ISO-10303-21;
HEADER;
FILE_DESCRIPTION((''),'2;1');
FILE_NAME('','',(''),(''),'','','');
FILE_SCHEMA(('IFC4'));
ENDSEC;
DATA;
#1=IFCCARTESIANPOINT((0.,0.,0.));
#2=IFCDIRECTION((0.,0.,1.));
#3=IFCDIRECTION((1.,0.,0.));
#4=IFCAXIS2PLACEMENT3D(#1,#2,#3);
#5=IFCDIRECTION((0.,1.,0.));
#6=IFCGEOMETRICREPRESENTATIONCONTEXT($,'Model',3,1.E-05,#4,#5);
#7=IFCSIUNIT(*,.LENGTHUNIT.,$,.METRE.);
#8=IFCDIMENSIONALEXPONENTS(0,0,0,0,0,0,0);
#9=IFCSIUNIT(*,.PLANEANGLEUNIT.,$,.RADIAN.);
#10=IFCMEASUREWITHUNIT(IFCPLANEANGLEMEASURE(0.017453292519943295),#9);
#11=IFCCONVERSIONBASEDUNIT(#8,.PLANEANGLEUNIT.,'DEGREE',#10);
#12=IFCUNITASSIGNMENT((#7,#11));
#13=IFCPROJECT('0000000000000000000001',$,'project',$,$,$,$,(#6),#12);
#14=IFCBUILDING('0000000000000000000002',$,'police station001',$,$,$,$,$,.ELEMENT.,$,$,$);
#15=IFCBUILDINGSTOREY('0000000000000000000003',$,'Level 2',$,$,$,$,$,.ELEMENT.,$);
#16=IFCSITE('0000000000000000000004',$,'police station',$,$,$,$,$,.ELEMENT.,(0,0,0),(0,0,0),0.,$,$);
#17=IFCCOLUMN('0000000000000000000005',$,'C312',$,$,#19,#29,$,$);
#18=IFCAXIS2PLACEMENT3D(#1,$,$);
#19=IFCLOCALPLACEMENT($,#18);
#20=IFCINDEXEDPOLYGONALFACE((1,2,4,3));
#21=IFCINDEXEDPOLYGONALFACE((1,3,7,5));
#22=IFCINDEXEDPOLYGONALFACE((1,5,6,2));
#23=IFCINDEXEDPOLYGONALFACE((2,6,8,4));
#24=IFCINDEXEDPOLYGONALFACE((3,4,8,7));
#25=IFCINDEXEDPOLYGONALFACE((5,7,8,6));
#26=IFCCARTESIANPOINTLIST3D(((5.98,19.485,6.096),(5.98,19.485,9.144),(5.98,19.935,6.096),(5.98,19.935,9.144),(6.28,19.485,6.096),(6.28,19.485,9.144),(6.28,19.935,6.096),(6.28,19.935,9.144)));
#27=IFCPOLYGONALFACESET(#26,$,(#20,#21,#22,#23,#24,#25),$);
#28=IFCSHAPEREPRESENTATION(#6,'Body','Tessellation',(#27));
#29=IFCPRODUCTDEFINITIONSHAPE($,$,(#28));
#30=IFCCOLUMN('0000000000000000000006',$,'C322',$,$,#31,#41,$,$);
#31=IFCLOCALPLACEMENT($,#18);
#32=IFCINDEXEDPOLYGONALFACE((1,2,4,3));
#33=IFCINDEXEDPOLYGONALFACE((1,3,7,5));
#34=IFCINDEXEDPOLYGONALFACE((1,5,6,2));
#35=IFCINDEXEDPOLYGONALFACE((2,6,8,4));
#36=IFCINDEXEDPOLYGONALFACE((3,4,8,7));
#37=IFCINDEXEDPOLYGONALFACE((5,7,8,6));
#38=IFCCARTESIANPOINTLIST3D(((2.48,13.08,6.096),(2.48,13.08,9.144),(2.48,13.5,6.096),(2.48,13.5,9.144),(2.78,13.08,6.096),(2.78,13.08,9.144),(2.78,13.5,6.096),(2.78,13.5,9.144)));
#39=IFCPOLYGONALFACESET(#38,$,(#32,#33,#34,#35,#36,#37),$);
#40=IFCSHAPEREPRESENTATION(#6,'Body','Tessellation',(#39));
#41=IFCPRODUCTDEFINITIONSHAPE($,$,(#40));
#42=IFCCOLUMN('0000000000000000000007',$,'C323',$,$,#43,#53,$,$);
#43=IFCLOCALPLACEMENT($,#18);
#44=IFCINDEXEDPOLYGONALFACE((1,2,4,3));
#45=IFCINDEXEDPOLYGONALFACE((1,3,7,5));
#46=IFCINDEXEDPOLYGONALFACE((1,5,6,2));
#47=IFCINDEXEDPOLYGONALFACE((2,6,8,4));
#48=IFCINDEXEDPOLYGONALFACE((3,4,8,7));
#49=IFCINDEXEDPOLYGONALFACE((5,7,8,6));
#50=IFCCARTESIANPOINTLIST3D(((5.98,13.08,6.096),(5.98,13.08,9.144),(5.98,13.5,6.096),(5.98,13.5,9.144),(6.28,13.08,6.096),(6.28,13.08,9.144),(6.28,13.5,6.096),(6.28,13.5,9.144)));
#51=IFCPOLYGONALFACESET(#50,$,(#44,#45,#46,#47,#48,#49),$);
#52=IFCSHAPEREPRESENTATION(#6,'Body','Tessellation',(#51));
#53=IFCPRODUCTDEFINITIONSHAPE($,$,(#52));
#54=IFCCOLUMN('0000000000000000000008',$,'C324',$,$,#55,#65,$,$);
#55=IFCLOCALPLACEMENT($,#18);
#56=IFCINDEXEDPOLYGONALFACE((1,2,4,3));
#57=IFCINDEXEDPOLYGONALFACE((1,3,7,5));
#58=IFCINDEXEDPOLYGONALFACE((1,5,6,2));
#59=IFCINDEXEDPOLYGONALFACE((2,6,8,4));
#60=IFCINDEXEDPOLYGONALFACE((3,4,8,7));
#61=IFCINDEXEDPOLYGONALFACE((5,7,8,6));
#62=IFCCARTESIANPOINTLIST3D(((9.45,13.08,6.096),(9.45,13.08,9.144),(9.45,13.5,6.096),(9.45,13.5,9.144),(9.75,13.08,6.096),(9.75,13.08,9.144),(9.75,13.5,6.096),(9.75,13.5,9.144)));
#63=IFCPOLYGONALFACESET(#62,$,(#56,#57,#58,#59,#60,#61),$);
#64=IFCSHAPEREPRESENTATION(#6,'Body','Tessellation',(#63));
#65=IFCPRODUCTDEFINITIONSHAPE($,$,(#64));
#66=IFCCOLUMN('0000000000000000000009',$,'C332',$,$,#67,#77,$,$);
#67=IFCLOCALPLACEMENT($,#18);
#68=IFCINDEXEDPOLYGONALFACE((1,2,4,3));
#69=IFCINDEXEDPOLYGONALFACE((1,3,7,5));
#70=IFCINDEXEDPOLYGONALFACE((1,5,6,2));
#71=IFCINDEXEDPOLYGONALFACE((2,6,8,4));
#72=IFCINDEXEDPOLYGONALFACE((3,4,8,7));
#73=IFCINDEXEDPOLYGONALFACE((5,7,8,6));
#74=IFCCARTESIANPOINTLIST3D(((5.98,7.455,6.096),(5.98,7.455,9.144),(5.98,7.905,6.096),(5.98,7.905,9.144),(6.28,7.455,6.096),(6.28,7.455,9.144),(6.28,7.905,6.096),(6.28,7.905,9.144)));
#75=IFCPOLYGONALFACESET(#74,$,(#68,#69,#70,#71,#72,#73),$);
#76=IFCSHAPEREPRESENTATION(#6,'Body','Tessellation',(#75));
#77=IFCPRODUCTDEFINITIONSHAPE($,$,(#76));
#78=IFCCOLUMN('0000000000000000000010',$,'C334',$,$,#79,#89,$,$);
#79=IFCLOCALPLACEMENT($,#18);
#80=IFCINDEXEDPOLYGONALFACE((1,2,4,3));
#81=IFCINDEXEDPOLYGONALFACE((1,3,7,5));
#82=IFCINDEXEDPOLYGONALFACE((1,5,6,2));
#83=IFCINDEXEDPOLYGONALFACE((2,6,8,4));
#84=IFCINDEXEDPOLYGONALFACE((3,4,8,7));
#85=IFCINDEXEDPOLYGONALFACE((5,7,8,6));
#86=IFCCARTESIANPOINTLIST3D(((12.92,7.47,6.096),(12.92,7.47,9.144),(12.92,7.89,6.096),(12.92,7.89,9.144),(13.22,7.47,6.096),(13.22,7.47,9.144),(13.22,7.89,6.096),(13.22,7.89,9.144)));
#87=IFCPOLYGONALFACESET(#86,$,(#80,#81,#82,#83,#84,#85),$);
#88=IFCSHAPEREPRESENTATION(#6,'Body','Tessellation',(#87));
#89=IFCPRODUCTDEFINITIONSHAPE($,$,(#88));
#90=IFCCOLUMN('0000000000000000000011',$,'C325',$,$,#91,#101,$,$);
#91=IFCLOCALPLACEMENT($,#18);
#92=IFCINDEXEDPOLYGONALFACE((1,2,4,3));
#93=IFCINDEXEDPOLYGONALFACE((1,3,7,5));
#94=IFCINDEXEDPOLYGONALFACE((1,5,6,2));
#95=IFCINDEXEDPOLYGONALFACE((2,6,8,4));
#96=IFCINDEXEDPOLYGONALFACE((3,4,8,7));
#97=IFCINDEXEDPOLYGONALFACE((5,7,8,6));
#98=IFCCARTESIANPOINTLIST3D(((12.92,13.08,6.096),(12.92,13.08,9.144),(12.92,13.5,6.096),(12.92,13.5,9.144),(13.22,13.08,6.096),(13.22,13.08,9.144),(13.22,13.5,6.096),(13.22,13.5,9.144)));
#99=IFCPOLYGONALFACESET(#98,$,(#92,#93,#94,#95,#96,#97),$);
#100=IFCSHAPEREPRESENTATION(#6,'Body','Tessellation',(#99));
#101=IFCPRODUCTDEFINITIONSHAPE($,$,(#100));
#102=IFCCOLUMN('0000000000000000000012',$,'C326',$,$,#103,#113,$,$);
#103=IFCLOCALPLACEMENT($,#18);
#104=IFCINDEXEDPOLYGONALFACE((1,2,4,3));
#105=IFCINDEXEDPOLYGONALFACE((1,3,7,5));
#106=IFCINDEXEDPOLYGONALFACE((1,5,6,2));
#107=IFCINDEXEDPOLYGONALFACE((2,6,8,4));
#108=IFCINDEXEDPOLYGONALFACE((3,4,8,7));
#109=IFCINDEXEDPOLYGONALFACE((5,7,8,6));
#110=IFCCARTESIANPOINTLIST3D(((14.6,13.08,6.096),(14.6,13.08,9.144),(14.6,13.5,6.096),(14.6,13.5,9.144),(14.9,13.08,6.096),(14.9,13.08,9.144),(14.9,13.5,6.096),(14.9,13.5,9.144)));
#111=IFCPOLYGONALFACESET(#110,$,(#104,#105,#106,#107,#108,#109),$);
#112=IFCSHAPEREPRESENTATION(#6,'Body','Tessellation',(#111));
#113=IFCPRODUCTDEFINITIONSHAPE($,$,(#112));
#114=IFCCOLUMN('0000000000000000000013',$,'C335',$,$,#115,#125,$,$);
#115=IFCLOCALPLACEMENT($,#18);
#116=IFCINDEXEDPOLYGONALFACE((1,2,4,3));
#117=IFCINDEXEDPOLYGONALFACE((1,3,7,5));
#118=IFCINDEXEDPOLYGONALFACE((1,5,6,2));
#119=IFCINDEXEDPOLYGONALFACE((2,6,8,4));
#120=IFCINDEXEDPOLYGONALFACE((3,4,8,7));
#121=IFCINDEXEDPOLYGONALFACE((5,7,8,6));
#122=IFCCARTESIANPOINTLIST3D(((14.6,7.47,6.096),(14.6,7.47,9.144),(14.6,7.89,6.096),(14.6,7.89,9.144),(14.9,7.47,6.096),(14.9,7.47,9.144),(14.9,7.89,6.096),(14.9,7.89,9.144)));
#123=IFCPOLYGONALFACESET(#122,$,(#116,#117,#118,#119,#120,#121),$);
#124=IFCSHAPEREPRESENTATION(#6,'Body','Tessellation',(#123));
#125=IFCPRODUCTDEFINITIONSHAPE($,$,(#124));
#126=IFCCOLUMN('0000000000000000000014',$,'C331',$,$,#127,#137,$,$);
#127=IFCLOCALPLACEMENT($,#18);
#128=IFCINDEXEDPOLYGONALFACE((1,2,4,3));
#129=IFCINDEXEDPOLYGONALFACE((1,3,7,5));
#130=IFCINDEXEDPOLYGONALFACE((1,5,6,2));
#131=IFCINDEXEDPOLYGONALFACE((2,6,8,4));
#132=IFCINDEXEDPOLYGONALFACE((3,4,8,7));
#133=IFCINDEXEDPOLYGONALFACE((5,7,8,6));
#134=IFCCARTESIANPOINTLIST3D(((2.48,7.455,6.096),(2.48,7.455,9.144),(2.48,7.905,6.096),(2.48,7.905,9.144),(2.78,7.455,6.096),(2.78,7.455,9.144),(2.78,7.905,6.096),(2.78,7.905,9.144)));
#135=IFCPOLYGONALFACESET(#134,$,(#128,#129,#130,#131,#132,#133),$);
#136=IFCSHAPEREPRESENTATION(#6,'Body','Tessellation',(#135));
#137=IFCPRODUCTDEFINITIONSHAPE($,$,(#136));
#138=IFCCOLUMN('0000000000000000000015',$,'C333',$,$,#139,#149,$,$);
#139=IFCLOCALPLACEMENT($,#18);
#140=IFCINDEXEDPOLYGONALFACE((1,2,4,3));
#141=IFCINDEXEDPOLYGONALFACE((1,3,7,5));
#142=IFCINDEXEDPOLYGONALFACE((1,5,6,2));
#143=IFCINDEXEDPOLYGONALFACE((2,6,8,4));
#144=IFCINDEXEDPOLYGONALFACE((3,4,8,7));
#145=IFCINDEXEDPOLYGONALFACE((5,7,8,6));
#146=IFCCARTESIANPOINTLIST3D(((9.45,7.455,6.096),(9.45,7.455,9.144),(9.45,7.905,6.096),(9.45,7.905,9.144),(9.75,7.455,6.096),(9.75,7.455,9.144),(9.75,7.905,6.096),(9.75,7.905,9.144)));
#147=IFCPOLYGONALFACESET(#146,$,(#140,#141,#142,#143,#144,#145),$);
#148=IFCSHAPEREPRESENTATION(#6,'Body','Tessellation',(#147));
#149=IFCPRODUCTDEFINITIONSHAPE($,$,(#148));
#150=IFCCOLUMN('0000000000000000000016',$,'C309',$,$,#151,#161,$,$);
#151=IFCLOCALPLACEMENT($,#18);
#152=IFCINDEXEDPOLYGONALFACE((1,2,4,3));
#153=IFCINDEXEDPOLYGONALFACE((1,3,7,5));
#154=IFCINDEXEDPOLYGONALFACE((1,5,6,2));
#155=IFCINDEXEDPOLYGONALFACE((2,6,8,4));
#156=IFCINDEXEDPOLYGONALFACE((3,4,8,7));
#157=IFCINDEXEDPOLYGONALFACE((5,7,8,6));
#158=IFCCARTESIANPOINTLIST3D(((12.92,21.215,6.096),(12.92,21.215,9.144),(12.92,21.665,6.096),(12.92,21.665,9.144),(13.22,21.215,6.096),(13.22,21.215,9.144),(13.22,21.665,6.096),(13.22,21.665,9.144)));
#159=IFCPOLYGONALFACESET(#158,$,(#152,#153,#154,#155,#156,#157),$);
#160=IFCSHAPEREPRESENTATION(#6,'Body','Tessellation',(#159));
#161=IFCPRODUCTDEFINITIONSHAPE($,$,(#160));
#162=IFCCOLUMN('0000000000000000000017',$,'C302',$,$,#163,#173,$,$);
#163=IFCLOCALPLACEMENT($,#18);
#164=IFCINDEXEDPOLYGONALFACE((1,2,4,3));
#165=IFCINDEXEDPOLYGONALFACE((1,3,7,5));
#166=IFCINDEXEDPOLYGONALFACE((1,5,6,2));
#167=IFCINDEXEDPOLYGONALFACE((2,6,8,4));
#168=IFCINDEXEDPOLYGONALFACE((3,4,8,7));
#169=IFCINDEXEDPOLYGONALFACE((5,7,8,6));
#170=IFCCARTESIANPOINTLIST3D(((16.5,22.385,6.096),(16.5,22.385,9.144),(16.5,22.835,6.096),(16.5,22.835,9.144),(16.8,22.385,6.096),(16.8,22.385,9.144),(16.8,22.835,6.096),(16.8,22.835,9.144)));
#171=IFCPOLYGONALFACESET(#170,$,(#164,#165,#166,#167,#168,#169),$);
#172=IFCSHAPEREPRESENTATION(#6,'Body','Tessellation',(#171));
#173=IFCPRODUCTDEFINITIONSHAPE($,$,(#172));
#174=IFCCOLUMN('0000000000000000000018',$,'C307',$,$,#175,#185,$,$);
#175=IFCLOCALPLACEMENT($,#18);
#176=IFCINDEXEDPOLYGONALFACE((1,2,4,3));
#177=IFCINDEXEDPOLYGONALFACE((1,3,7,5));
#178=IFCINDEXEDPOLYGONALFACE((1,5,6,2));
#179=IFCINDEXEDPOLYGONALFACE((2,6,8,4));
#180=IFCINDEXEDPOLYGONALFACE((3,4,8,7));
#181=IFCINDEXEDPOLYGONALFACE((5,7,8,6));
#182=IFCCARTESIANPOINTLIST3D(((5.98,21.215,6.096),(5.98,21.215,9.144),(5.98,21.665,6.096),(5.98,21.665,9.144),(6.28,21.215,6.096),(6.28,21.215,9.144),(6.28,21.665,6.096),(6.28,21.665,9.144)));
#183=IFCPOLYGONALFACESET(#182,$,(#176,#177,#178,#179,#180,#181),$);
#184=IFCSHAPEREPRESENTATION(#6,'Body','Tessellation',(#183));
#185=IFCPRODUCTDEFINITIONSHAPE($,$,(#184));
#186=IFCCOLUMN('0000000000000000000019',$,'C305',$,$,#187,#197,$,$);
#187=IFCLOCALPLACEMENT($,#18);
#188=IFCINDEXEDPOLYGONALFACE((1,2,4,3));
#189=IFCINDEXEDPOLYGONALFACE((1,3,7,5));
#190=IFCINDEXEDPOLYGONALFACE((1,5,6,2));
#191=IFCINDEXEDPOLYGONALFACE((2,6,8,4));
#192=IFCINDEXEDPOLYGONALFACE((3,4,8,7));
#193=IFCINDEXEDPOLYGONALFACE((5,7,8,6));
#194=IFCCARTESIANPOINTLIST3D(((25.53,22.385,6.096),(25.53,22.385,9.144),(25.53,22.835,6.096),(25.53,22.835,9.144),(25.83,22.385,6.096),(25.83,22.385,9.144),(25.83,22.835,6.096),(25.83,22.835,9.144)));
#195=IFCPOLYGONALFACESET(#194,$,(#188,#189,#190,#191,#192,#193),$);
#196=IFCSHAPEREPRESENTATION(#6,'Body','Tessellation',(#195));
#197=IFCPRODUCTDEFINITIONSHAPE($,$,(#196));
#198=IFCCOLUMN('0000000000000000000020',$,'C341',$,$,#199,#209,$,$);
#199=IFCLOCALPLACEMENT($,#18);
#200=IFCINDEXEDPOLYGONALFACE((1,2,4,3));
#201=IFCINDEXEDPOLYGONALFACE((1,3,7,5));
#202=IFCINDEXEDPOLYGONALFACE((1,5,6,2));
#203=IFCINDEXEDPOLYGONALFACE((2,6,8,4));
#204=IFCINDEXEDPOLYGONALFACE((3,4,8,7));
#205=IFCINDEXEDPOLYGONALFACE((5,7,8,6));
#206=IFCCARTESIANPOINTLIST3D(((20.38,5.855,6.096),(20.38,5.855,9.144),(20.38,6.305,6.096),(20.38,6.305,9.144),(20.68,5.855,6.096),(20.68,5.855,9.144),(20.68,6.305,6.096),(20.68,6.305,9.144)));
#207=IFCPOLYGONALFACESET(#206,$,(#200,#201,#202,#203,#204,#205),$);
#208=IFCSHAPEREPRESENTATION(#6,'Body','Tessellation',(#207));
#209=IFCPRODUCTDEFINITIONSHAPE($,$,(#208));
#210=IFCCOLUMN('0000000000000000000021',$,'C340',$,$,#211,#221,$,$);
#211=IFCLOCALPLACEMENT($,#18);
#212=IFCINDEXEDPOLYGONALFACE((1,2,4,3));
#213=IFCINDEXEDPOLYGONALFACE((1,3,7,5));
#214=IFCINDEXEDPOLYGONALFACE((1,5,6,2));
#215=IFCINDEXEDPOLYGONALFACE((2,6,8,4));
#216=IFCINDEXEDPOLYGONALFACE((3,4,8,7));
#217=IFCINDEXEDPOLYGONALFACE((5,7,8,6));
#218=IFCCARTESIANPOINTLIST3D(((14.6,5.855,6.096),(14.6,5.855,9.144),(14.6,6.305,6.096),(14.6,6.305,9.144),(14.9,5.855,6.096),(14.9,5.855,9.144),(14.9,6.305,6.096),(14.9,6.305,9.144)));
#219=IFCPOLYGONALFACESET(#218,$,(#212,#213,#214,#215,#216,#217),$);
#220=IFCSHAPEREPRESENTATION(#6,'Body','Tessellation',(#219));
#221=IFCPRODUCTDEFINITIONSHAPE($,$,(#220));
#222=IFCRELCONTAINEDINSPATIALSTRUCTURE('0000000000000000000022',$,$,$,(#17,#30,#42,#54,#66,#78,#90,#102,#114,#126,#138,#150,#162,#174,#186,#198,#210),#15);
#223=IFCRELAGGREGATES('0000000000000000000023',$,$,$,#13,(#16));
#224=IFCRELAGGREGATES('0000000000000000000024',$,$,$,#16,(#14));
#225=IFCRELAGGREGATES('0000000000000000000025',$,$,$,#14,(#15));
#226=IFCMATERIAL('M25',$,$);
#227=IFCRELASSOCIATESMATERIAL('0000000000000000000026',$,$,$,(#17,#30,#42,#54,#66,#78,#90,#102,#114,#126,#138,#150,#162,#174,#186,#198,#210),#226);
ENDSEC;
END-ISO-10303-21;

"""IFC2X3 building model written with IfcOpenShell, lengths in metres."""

from ifc_helpers import new_model, entity, si_unit, converted_unit, direction, frame, frame_2d, origin_with_axes, place, context, project, spatial, rectangle, extrude, material, element, save


model = new_model("IFC2X3")

# Units and contexts
model_context = context("Model", 3, precision=1e-05, world=origin_with_axes(), true_north=direction((0.0, 1.0, 0.0)))
ifc_project = project(units=[si_unit("LENGTHUNIT", "METRE"), converted_unit("PLANEANGLEUNIT", "DEGREE", entity("IfcPlaneAngleMeasure", 0.017453292519943295), si_unit("PLANEANGLEUNIT", "RADIAN"), dimensions=[0, 0, 0, 0, 0, 0, 0])], contexts=[model_context])

# Site, building, storey
site = spatial("IfcSite", under=ifc_project, Name="police station", CompositionType="ELEMENT", RefLatitude=(0, 0, 0), RefLongitude=(0, 0, 0), RefElevation=0.0)
building = spatial("IfcBuilding", under=site, Name="police station001", CompositionType="ELEMENT")
storey = spatial("IfcBuildingStorey", under=building, Name="Level 2", CompositionType="ELEMENT")

# Columns
ifc_material = material(Name="M25")
placement = place(None, origin_with_axes())
element("IfcColumn", 1, at=placement, inside=storey, material=ifc_material, Name="C312", context=model_context, shape_type="SweptSolid", body=[
    extrude(rectangle(XDim=0.3, YDim=0.45, at=frame_2d((0.0, 0.0), x_axis=(1.0, 0.0, 0.0))), frame((6.13, 19.71, 6.096), z_axis=(0.0, 0.0, 1.0), x_axis=(1.0, 0.0, 0.0)), (0.0, 0.0, 1.0), 3.048),
])
element("IfcColumn", 2, at=placement, inside=storey, material=ifc_material, Name="C322", context=model_context, shape_type="SweptSolid", body=[
    extrude(rectangle(XDim=0.3, YDim=0.42, at=frame_2d((0.0, 0.0), x_axis=(1.0, 0.0, 0.0))), frame((2.63, 13.29, 6.096), z_axis=(0.0, 0.0, 1.0), x_axis=(1.0, 0.0, 0.0)), (0.0, 0.0, 1.0), 3.048),
])
element("IfcColumn", 3, at=placement, inside=storey, material=ifc_material, Name="C323", context=model_context, shape_type="SweptSolid", body=[
    extrude(rectangle(XDim=0.3, YDim=0.42, at=frame_2d((0.0, 0.0), x_axis=(1.0, 0.0, 0.0))), frame((6.13, 13.29, 6.096), z_axis=(0.0, 0.0, 1.0), x_axis=(1.0, 0.0, 0.0)), (0.0, 0.0, 1.0), 3.048),
])
element("IfcColumn", 4, at=placement, inside=storey, material=ifc_material, Name="C324", context=model_context, shape_type="SweptSolid", body=[
    extrude(rectangle(XDim=0.3, YDim=0.42, at=frame_2d((0.0, 0.0), x_axis=(1.0, 0.0, 0.0))), frame((9.6, 13.29, 6.096), z_axis=(0.0, 0.0, 1.0), x_axis=(1.0, 0.0, 0.0)), (0.0, 0.0, 1.0), 3.048),
])
element("IfcColumn", 5, at=placement, inside=storey, material=ifc_material, Name="C332", context=model_context, shape_type="SweptSolid", body=[
    extrude(rectangle(XDim=0.3, YDim=0.45, at=frame_2d((0.0, 0.0), x_axis=(1.0, 0.0, 0.0))), frame((6.13, 7.68, 6.096), z_axis=(0.0, 0.0, 1.0), x_axis=(1.0, 0.0, 0.0)), (0.0, 0.0, 1.0), 3.048),
])
element("IfcColumn", 6, at=placement, inside=storey, material=ifc_material, Name="C334", context=model_context, shape_type="SweptSolid", body=[
    extrude(rectangle(XDim=0.3, YDim=0.42, at=frame_2d((0.0, 0.0), x_axis=(1.0, 0.0, 0.0))), frame((13.07, 7.68, 6.096), z_axis=(0.0, 0.0, 1.0), x_axis=(1.0, 0.0, 0.0)), (0.0, 0.0, 1.0), 3.048),
])
element("IfcColumn", 7, at=placement, inside=storey, material=ifc_material, Name="C325", context=model_context, shape_type="SweptSolid", body=[
    extrude(rectangle(XDim=0.3, YDim=0.42, at=frame_2d((0.0, 0.0), x_axis=(1.0, 0.0, 0.0))), frame((13.07, 13.29, 6.096), z_axis=(0.0, 0.0, 1.0), x_axis=(1.0, 0.0, 0.0)), (0.0, 0.0, 1.0), 3.048),
])
element("IfcColumn", 8, at=placement, inside=storey, material=ifc_material, Name="C326", context=model_context, shape_type="SweptSolid", body=[
    extrude(rectangle(XDim=0.3, YDim=0.42, at=frame_2d((0.0, 0.0), x_axis=(1.0, 0.0, 0.0))), frame((14.75, 13.29, 6.096), z_axis=(0.0, 0.0, 1.0), x_axis=(1.0, 0.0, 0.0)), (0.0, 0.0, 1.0), 3.048),
])
element("IfcColumn", 9, at=placement, inside=storey, material=ifc_material, Name="C335", context=model_context, shape_type="SweptSolid", body=[
    extrude(rectangle(XDim=0.3, YDim=0.42, at=frame_2d((0.0, 0.0), x_axis=(1.0, 0.0, 0.0))), frame((14.75, 7.68, 6.096), z_axis=(0.0, 0.0, 1.0), x_axis=(1.0, 0.0, 0.0)), (0.0, 0.0, 1.0), 3.048),
])
element("IfcColumn", 10, at=placement, inside=storey, material=ifc_material, Name="C331", context=model_context, shape_type="SweptSolid", body=[
    extrude(rectangle(XDim=0.3, YDim=0.45, at=frame_2d((0.0, 0.0), x_axis=(1.0, 0.0, 0.0))), frame((2.63, 7.68, 6.096), z_axis=(0.0, 0.0, 1.0), x_axis=(1.0, 0.0, 0.0)), (0.0, 0.0, 1.0), 3.048),
])
element("IfcColumn", 11, at=placement, inside=storey, material=ifc_material, Name="C333", context=model_context, shape_type="SweptSolid", body=[
    extrude(rectangle(XDim=0.3, YDim=0.45, at=frame_2d((0.0, 0.0), x_axis=(1.0, 0.0, 0.0))), frame((9.6, 7.68, 6.096), z_axis=(0.0, 0.0, 1.0), x_axis=(1.0, 0.0, 0.0)), (0.0, 0.0, 1.0), 3.048),
])
element("IfcColumn", 12, at=placement, inside=storey, material=ifc_material, Name="C309", context=model_context, shape_type="SweptSolid", body=[
    extrude(rectangle(XDim=0.3, YDim=0.45, at=frame_2d((0.0, 0.0), x_axis=(1.0, 0.0, 0.0))), frame((13.07, 21.44, 6.096), z_axis=(0.0, 0.0, 1.0), x_axis=(1.0, 0.0, 0.0)), (0.0, 0.0, 1.0), 3.048),
])
element("IfcColumn", 13, at=placement, inside=storey, material=ifc_material, Name="C302", context=model_context, shape_type="SweptSolid", body=[
    extrude(rectangle(XDim=0.3, YDim=0.45, at=frame_2d((0.0, 0.0), x_axis=(1.0, 0.0, 0.0))), frame((16.65, 22.61, 6.096), z_axis=(0.0, 0.0, 1.0), x_axis=(1.0, 0.0, 0.0)), (0.0, 0.0, 1.0), 3.048),
])
element("IfcColumn", 14, at=placement, inside=storey, material=ifc_material, Name="C307", context=model_context, shape_type="SweptSolid", body=[
    extrude(rectangle(XDim=0.3, YDim=0.45, at=frame_2d((0.0, 0.0), x_axis=(1.0, 0.0, 0.0))), frame((6.13, 21.44, 6.096), z_axis=(0.0, 0.0, 1.0), x_axis=(1.0, 0.0, 0.0)), (0.0, 0.0, 1.0), 3.048),
])
element("IfcColumn", 15, at=placement, inside=storey, material=ifc_material, Name="C305", context=model_context, shape_type="SweptSolid", body=[
    extrude(rectangle(XDim=0.3, YDim=0.45, at=frame_2d((0.0, 0.0), x_axis=(1.0, 0.0, 0.0))), frame((25.68, 22.61, 6.096), z_axis=(0.0, 0.0, 1.0), x_axis=(1.0, 0.0, 0.0)), (0.0, 0.0, 1.0), 3.048),
])
element("IfcColumn", 16, at=placement, inside=storey, material=ifc_material, Name="C341", context=model_context, shape_type="SweptSolid", body=[
    extrude(rectangle(XDim=0.3, YDim=0.45, at=frame_2d((0.0, 0.0), x_axis=(1.0, 0.0, 0.0))), frame((20.53, 6.08, 6.096), z_axis=(0.0, 0.0, 1.0), x_axis=(1.0, 0.0, 0.0)), (0.0, 0.0, 1.0), 3.048),
])
element("IfcColumn", 17, at=placement, inside=storey, material=ifc_material, Name="C340", context=model_context, shape_type="SweptSolid", body=[
    extrude(rectangle(XDim=0.3, YDim=0.45, at=frame_2d((0.0, 0.0), x_axis=(1.0, 0.0, 0.0))), frame((14.75, 6.08, 6.096), z_axis=(0.0, 0.0, 1.0), x_axis=(1.0, 0.0, 0.0)), (0.0, 0.0, 1.0), 3.048),
])

save(model, "model.ifc")
